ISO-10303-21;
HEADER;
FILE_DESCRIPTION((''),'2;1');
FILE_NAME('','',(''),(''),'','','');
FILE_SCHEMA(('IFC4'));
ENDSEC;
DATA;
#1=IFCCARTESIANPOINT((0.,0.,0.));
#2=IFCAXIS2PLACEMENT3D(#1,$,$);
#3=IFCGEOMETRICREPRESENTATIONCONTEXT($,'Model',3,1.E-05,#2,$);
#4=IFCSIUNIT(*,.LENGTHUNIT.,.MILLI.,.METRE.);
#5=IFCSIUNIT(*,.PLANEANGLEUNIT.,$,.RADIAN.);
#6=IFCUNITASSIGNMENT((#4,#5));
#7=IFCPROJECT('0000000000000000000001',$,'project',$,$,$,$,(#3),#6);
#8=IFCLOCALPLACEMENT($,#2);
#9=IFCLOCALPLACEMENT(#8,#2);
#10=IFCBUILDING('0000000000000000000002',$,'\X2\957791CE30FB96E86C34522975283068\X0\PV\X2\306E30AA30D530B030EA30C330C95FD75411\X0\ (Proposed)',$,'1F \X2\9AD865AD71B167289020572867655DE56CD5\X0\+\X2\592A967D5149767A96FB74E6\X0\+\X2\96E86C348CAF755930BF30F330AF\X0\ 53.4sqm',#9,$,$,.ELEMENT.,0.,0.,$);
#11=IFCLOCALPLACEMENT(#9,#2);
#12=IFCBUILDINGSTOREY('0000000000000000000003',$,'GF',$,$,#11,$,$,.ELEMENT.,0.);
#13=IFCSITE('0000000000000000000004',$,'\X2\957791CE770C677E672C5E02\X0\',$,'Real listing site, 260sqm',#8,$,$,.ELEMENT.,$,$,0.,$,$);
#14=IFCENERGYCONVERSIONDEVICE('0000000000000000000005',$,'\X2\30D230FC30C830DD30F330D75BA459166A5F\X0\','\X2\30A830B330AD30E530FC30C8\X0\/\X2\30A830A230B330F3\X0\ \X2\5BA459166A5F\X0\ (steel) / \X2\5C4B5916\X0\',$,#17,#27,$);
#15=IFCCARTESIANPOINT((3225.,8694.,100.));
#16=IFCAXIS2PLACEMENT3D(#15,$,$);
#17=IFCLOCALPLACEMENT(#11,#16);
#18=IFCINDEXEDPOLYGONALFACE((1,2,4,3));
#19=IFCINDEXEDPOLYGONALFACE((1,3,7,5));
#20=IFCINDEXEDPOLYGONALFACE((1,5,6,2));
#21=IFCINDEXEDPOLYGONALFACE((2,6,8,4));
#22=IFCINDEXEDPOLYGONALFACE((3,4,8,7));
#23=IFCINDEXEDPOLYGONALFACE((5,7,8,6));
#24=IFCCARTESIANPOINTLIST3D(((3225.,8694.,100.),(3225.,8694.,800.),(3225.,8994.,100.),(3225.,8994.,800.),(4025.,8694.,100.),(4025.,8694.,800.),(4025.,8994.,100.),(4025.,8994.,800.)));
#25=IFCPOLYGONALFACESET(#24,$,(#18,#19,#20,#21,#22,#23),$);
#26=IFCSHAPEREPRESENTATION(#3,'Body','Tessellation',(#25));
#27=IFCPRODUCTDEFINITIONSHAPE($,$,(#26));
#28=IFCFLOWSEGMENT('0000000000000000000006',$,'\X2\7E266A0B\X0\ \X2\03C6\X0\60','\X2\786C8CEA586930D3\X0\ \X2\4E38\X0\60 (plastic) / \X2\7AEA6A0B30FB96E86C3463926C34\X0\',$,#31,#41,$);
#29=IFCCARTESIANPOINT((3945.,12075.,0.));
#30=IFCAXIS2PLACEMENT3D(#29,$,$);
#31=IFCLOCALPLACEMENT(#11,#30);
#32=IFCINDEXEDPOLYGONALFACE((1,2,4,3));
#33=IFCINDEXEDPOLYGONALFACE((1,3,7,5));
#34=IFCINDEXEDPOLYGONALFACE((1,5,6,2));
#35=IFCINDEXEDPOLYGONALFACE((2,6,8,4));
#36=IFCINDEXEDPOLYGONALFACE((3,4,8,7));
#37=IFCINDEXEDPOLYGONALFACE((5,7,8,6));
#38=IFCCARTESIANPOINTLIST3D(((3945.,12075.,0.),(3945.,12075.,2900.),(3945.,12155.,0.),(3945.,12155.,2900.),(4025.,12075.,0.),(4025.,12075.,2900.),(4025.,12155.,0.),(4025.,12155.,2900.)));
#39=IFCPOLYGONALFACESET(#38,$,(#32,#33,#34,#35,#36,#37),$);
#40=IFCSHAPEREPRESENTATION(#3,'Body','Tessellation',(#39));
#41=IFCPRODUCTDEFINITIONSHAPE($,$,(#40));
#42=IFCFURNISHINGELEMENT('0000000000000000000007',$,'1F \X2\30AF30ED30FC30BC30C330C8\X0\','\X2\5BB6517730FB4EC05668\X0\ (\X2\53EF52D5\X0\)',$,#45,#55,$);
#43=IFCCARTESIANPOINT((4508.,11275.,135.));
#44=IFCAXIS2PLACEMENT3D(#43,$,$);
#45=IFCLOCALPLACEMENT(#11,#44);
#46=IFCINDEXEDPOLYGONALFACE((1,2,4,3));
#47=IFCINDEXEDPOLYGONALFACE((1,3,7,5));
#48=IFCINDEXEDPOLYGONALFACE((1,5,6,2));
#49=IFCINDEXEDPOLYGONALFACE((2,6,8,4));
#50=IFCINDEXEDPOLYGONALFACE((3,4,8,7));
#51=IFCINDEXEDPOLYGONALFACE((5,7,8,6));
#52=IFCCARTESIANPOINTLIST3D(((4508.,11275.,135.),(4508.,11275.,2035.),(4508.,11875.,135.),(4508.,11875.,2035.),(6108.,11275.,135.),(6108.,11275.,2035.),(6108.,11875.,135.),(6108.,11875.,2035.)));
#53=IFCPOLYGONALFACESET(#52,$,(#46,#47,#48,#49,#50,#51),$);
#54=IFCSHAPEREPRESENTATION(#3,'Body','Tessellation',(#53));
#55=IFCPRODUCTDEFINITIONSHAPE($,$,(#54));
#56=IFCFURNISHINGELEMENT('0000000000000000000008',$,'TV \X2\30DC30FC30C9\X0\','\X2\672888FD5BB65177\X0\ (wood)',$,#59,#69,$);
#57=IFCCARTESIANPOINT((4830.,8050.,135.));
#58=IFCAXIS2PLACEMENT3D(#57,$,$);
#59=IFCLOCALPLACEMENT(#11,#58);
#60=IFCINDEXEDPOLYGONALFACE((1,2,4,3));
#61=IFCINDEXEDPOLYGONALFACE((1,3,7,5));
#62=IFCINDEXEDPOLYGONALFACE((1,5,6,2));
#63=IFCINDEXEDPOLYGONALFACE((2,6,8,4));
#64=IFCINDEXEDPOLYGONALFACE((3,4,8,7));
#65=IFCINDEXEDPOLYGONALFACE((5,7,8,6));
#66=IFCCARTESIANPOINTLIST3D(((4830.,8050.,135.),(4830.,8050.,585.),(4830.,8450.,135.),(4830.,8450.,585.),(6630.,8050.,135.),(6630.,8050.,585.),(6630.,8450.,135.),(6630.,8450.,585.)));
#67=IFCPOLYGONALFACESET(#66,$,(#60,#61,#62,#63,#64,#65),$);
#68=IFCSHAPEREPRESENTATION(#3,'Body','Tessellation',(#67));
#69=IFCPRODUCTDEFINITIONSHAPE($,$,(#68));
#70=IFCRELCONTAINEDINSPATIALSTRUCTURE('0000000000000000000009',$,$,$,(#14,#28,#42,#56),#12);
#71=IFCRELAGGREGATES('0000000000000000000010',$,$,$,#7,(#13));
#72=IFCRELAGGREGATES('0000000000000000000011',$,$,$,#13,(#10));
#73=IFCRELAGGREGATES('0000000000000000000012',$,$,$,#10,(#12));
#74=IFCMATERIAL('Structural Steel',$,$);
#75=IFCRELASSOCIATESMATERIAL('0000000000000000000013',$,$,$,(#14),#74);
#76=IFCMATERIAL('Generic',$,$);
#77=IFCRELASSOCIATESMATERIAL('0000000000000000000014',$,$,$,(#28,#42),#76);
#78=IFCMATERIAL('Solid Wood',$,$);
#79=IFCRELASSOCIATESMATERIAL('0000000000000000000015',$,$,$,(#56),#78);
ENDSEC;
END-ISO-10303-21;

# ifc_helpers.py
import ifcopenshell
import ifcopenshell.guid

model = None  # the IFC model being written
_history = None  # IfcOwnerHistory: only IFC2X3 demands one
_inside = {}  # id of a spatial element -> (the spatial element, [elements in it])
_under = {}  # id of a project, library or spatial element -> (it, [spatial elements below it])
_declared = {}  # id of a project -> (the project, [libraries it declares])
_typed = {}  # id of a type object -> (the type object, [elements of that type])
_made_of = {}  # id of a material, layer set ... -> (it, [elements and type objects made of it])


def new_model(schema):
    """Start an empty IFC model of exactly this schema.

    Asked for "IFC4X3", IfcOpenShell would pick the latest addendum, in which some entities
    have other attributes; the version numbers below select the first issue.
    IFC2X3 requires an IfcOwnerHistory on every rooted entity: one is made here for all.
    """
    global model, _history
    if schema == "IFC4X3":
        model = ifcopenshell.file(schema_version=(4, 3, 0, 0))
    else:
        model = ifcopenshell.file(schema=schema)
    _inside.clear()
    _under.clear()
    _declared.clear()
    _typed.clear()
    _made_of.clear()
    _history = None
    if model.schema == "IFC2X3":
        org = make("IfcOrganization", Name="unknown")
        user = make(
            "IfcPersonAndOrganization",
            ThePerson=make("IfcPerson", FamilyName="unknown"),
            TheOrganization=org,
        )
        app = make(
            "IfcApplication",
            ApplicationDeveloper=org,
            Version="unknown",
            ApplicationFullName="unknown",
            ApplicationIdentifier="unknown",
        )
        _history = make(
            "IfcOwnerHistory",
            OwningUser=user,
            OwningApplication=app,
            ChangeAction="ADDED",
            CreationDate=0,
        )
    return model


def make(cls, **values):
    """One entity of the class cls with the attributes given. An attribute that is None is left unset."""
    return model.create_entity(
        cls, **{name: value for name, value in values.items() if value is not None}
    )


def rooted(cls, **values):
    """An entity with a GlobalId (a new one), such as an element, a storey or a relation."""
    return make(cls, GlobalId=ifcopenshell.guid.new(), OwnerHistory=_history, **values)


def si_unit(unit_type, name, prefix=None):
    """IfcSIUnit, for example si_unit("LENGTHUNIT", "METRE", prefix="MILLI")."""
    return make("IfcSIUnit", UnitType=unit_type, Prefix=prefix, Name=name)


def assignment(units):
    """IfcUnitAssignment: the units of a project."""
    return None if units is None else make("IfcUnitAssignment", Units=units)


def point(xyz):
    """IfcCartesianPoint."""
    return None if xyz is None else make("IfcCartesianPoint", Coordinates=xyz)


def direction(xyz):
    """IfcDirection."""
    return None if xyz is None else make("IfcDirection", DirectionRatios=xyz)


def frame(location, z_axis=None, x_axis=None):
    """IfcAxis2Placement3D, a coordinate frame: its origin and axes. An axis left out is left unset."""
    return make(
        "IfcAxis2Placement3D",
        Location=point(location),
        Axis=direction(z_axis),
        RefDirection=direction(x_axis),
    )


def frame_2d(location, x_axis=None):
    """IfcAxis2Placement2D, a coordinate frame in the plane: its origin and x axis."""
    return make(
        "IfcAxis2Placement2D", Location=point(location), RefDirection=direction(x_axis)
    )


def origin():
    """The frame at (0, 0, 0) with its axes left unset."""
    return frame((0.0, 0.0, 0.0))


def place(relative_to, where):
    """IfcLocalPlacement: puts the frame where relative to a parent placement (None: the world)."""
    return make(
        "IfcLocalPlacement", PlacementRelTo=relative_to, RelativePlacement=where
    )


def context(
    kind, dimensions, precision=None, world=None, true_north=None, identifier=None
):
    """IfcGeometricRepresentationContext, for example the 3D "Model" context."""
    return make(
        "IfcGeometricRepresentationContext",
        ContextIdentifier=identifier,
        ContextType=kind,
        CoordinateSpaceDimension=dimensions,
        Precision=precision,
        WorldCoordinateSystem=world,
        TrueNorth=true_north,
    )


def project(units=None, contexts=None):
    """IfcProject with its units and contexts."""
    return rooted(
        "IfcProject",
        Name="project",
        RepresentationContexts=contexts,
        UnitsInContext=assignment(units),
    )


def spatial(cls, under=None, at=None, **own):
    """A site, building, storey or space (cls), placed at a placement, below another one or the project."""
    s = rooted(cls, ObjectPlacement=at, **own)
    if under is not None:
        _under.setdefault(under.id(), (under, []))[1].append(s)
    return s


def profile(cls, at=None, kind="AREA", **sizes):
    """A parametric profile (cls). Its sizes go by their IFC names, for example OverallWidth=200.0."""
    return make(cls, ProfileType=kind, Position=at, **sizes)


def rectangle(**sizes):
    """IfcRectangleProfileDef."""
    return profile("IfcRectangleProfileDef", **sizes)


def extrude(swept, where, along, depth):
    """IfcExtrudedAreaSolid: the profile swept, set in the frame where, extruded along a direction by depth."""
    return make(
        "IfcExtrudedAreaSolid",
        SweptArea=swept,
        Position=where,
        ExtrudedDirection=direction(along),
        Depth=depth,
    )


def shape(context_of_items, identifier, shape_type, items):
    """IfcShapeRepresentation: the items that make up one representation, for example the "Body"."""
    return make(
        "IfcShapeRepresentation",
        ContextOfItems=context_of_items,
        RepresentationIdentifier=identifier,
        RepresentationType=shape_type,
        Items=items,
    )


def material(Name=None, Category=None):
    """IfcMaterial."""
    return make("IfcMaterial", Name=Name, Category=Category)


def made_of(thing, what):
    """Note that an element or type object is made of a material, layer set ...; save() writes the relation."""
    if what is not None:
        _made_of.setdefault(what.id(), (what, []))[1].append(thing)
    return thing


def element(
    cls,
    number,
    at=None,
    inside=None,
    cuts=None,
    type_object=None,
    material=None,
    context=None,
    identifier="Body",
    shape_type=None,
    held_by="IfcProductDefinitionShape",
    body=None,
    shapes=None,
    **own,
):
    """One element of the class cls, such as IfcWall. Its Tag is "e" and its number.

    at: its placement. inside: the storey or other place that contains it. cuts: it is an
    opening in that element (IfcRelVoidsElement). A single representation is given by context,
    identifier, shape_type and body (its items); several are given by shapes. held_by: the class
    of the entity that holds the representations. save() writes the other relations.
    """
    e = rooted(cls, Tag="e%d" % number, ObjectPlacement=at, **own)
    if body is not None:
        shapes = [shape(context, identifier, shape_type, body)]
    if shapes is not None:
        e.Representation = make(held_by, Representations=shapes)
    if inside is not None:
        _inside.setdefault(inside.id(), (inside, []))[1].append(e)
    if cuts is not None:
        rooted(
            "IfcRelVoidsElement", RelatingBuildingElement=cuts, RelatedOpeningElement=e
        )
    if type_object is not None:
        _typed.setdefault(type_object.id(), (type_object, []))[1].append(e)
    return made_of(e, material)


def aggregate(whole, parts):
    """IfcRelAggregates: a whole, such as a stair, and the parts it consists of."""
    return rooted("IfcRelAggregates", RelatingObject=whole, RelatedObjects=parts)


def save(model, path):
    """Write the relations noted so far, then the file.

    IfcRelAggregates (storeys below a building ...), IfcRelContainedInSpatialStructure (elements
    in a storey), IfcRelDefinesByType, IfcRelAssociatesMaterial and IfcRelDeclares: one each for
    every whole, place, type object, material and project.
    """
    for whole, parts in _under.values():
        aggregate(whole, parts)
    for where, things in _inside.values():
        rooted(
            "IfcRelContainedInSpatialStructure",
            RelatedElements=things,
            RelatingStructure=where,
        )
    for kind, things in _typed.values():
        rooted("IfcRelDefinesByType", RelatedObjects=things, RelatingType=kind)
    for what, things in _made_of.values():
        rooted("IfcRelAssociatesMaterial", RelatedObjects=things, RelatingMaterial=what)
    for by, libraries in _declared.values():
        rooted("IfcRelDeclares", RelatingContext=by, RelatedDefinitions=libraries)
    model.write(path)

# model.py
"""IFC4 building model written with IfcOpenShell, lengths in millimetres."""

from ifc_helpers import new_model, si_unit, frame, frame_2d, origin, place, context, project, spatial, rectangle, extrude, material, element, save


model = new_model("IFC4")

# Units and contexts
model_context = context("Model", 3, precision=1e-05, world=origin())
ifc_project = project(units=[si_unit("LENGTHUNIT", "METRE", prefix="MILLI"), si_unit("PLANEANGLEUNIT", "RADIAN")], contexts=[model_context])

# Site, building, storey
site_placement = place(None, origin())
site = spatial("IfcSite", under=ifc_project, at=site_placement, Name="長野県松本市", ObjectType="Real listing site, 260sqm", CompositionType="ELEMENT", RefElevation=0.0)
building_placement = place(site_placement, origin())
building = spatial("IfcBuilding", under=site, at=building_placement, Name="長野・雨水利用とPVのオフグリッド志向 (Proposed)", ObjectType="1F 高断熱木造在来工法+太陽光発電瓦+雨水貯留タンク 53.4sqm", CompositionType="ELEMENT", ElevationOfRefHeight=0.0, ElevationOfTerrain=0.0)
storey_placement = place(building_placement, origin())
storey = spatial("IfcBuildingStorey", under=building, at=storey_placement, Name="GF", CompositionType="ELEMENT", Elevation=0.0)

# Shared definitions
ifc_material_1 = material(Name="Solid Wood")

# Shared definitions
ifc_material_2 = material(Name="Structural Steel")

# Shared definitions
ifc_material_3 = material(Name="Generic")

# Energy conversion device
energy_conversion_device_placement = place(storey_placement, frame((3225.0, 8694.0, 100.0)))
element("IfcEnergyConversionDevice", 1, at=energy_conversion_device_placement, inside=storey, material=ifc_material_2, Name="ヒートポンプ室外機", Description="エコキュート/エアコン 室外機 (steel) / 屋外", context=model_context, shape_type="SweptSolid", body=[
    extrude(rectangle(XDim=800.0, YDim=300.0, at=frame_2d((400.0, 150.0))), frame((3225.0, 8694.0, 100.0)), (0.0, 0.0, 1.0), 700.0),
])

# Flow segment
flow_segment_1_placement = place(storey_placement, frame((3945.0, 12075.0, 0.0)))
element("IfcFlowSegment", 2, at=flow_segment_1_placement, inside=storey, material=ifc_material_3, Name="縦樋 φ60", Description="硬質塩ビ 丸60 (plastic) / 竪樋・雨水排水", context=model_context, shape_type="SweptSolid", body=[
    extrude(rectangle(XDim=80.0, YDim=80.0, at=frame_2d((40.0, 40.0))), frame((3945.0, 12075.0, 0.0)), (0.0, 0.0, 1.0), 2900.0),
])

# Furnishing elements
furnishing_1_placement = place(storey_placement, frame((4508.0, 11275.0, 135.0)))
element("IfcFurnishingElement", 3, at=furnishing_1_placement, inside=storey, material=ifc_material_3, Name="1F クローゼット", Description="家具・什器 (可動)", context=model_context, shape_type="SweptSolid", body=[
    extrude(rectangle(XDim=1600.0, YDim=600.0, at=frame_2d((800.0, 300.0))), frame((4508.0, 11275.0, 135.0)), (0.0, 0.0, 1.0), 1900.0),
])
furnishing_2_placement = place(storey_placement, frame((4830.0, 8050.0, 135.0)))
element("IfcFurnishingElement", 4, at=furnishing_2_placement, inside=storey, material=ifc_material_1, Name="TV ボード", Description="木製家具 (wood)", context=model_context, shape_type="SweptSolid", body=[
    extrude(rectangle(XDim=1800.0, YDim=400.0, at=frame_2d((900.0, 200.0))), frame((4830.0, 8050.0, 135.0)), (0.0, 0.0, 1.0), 450.0),
])

save(model, "model.ifc")
